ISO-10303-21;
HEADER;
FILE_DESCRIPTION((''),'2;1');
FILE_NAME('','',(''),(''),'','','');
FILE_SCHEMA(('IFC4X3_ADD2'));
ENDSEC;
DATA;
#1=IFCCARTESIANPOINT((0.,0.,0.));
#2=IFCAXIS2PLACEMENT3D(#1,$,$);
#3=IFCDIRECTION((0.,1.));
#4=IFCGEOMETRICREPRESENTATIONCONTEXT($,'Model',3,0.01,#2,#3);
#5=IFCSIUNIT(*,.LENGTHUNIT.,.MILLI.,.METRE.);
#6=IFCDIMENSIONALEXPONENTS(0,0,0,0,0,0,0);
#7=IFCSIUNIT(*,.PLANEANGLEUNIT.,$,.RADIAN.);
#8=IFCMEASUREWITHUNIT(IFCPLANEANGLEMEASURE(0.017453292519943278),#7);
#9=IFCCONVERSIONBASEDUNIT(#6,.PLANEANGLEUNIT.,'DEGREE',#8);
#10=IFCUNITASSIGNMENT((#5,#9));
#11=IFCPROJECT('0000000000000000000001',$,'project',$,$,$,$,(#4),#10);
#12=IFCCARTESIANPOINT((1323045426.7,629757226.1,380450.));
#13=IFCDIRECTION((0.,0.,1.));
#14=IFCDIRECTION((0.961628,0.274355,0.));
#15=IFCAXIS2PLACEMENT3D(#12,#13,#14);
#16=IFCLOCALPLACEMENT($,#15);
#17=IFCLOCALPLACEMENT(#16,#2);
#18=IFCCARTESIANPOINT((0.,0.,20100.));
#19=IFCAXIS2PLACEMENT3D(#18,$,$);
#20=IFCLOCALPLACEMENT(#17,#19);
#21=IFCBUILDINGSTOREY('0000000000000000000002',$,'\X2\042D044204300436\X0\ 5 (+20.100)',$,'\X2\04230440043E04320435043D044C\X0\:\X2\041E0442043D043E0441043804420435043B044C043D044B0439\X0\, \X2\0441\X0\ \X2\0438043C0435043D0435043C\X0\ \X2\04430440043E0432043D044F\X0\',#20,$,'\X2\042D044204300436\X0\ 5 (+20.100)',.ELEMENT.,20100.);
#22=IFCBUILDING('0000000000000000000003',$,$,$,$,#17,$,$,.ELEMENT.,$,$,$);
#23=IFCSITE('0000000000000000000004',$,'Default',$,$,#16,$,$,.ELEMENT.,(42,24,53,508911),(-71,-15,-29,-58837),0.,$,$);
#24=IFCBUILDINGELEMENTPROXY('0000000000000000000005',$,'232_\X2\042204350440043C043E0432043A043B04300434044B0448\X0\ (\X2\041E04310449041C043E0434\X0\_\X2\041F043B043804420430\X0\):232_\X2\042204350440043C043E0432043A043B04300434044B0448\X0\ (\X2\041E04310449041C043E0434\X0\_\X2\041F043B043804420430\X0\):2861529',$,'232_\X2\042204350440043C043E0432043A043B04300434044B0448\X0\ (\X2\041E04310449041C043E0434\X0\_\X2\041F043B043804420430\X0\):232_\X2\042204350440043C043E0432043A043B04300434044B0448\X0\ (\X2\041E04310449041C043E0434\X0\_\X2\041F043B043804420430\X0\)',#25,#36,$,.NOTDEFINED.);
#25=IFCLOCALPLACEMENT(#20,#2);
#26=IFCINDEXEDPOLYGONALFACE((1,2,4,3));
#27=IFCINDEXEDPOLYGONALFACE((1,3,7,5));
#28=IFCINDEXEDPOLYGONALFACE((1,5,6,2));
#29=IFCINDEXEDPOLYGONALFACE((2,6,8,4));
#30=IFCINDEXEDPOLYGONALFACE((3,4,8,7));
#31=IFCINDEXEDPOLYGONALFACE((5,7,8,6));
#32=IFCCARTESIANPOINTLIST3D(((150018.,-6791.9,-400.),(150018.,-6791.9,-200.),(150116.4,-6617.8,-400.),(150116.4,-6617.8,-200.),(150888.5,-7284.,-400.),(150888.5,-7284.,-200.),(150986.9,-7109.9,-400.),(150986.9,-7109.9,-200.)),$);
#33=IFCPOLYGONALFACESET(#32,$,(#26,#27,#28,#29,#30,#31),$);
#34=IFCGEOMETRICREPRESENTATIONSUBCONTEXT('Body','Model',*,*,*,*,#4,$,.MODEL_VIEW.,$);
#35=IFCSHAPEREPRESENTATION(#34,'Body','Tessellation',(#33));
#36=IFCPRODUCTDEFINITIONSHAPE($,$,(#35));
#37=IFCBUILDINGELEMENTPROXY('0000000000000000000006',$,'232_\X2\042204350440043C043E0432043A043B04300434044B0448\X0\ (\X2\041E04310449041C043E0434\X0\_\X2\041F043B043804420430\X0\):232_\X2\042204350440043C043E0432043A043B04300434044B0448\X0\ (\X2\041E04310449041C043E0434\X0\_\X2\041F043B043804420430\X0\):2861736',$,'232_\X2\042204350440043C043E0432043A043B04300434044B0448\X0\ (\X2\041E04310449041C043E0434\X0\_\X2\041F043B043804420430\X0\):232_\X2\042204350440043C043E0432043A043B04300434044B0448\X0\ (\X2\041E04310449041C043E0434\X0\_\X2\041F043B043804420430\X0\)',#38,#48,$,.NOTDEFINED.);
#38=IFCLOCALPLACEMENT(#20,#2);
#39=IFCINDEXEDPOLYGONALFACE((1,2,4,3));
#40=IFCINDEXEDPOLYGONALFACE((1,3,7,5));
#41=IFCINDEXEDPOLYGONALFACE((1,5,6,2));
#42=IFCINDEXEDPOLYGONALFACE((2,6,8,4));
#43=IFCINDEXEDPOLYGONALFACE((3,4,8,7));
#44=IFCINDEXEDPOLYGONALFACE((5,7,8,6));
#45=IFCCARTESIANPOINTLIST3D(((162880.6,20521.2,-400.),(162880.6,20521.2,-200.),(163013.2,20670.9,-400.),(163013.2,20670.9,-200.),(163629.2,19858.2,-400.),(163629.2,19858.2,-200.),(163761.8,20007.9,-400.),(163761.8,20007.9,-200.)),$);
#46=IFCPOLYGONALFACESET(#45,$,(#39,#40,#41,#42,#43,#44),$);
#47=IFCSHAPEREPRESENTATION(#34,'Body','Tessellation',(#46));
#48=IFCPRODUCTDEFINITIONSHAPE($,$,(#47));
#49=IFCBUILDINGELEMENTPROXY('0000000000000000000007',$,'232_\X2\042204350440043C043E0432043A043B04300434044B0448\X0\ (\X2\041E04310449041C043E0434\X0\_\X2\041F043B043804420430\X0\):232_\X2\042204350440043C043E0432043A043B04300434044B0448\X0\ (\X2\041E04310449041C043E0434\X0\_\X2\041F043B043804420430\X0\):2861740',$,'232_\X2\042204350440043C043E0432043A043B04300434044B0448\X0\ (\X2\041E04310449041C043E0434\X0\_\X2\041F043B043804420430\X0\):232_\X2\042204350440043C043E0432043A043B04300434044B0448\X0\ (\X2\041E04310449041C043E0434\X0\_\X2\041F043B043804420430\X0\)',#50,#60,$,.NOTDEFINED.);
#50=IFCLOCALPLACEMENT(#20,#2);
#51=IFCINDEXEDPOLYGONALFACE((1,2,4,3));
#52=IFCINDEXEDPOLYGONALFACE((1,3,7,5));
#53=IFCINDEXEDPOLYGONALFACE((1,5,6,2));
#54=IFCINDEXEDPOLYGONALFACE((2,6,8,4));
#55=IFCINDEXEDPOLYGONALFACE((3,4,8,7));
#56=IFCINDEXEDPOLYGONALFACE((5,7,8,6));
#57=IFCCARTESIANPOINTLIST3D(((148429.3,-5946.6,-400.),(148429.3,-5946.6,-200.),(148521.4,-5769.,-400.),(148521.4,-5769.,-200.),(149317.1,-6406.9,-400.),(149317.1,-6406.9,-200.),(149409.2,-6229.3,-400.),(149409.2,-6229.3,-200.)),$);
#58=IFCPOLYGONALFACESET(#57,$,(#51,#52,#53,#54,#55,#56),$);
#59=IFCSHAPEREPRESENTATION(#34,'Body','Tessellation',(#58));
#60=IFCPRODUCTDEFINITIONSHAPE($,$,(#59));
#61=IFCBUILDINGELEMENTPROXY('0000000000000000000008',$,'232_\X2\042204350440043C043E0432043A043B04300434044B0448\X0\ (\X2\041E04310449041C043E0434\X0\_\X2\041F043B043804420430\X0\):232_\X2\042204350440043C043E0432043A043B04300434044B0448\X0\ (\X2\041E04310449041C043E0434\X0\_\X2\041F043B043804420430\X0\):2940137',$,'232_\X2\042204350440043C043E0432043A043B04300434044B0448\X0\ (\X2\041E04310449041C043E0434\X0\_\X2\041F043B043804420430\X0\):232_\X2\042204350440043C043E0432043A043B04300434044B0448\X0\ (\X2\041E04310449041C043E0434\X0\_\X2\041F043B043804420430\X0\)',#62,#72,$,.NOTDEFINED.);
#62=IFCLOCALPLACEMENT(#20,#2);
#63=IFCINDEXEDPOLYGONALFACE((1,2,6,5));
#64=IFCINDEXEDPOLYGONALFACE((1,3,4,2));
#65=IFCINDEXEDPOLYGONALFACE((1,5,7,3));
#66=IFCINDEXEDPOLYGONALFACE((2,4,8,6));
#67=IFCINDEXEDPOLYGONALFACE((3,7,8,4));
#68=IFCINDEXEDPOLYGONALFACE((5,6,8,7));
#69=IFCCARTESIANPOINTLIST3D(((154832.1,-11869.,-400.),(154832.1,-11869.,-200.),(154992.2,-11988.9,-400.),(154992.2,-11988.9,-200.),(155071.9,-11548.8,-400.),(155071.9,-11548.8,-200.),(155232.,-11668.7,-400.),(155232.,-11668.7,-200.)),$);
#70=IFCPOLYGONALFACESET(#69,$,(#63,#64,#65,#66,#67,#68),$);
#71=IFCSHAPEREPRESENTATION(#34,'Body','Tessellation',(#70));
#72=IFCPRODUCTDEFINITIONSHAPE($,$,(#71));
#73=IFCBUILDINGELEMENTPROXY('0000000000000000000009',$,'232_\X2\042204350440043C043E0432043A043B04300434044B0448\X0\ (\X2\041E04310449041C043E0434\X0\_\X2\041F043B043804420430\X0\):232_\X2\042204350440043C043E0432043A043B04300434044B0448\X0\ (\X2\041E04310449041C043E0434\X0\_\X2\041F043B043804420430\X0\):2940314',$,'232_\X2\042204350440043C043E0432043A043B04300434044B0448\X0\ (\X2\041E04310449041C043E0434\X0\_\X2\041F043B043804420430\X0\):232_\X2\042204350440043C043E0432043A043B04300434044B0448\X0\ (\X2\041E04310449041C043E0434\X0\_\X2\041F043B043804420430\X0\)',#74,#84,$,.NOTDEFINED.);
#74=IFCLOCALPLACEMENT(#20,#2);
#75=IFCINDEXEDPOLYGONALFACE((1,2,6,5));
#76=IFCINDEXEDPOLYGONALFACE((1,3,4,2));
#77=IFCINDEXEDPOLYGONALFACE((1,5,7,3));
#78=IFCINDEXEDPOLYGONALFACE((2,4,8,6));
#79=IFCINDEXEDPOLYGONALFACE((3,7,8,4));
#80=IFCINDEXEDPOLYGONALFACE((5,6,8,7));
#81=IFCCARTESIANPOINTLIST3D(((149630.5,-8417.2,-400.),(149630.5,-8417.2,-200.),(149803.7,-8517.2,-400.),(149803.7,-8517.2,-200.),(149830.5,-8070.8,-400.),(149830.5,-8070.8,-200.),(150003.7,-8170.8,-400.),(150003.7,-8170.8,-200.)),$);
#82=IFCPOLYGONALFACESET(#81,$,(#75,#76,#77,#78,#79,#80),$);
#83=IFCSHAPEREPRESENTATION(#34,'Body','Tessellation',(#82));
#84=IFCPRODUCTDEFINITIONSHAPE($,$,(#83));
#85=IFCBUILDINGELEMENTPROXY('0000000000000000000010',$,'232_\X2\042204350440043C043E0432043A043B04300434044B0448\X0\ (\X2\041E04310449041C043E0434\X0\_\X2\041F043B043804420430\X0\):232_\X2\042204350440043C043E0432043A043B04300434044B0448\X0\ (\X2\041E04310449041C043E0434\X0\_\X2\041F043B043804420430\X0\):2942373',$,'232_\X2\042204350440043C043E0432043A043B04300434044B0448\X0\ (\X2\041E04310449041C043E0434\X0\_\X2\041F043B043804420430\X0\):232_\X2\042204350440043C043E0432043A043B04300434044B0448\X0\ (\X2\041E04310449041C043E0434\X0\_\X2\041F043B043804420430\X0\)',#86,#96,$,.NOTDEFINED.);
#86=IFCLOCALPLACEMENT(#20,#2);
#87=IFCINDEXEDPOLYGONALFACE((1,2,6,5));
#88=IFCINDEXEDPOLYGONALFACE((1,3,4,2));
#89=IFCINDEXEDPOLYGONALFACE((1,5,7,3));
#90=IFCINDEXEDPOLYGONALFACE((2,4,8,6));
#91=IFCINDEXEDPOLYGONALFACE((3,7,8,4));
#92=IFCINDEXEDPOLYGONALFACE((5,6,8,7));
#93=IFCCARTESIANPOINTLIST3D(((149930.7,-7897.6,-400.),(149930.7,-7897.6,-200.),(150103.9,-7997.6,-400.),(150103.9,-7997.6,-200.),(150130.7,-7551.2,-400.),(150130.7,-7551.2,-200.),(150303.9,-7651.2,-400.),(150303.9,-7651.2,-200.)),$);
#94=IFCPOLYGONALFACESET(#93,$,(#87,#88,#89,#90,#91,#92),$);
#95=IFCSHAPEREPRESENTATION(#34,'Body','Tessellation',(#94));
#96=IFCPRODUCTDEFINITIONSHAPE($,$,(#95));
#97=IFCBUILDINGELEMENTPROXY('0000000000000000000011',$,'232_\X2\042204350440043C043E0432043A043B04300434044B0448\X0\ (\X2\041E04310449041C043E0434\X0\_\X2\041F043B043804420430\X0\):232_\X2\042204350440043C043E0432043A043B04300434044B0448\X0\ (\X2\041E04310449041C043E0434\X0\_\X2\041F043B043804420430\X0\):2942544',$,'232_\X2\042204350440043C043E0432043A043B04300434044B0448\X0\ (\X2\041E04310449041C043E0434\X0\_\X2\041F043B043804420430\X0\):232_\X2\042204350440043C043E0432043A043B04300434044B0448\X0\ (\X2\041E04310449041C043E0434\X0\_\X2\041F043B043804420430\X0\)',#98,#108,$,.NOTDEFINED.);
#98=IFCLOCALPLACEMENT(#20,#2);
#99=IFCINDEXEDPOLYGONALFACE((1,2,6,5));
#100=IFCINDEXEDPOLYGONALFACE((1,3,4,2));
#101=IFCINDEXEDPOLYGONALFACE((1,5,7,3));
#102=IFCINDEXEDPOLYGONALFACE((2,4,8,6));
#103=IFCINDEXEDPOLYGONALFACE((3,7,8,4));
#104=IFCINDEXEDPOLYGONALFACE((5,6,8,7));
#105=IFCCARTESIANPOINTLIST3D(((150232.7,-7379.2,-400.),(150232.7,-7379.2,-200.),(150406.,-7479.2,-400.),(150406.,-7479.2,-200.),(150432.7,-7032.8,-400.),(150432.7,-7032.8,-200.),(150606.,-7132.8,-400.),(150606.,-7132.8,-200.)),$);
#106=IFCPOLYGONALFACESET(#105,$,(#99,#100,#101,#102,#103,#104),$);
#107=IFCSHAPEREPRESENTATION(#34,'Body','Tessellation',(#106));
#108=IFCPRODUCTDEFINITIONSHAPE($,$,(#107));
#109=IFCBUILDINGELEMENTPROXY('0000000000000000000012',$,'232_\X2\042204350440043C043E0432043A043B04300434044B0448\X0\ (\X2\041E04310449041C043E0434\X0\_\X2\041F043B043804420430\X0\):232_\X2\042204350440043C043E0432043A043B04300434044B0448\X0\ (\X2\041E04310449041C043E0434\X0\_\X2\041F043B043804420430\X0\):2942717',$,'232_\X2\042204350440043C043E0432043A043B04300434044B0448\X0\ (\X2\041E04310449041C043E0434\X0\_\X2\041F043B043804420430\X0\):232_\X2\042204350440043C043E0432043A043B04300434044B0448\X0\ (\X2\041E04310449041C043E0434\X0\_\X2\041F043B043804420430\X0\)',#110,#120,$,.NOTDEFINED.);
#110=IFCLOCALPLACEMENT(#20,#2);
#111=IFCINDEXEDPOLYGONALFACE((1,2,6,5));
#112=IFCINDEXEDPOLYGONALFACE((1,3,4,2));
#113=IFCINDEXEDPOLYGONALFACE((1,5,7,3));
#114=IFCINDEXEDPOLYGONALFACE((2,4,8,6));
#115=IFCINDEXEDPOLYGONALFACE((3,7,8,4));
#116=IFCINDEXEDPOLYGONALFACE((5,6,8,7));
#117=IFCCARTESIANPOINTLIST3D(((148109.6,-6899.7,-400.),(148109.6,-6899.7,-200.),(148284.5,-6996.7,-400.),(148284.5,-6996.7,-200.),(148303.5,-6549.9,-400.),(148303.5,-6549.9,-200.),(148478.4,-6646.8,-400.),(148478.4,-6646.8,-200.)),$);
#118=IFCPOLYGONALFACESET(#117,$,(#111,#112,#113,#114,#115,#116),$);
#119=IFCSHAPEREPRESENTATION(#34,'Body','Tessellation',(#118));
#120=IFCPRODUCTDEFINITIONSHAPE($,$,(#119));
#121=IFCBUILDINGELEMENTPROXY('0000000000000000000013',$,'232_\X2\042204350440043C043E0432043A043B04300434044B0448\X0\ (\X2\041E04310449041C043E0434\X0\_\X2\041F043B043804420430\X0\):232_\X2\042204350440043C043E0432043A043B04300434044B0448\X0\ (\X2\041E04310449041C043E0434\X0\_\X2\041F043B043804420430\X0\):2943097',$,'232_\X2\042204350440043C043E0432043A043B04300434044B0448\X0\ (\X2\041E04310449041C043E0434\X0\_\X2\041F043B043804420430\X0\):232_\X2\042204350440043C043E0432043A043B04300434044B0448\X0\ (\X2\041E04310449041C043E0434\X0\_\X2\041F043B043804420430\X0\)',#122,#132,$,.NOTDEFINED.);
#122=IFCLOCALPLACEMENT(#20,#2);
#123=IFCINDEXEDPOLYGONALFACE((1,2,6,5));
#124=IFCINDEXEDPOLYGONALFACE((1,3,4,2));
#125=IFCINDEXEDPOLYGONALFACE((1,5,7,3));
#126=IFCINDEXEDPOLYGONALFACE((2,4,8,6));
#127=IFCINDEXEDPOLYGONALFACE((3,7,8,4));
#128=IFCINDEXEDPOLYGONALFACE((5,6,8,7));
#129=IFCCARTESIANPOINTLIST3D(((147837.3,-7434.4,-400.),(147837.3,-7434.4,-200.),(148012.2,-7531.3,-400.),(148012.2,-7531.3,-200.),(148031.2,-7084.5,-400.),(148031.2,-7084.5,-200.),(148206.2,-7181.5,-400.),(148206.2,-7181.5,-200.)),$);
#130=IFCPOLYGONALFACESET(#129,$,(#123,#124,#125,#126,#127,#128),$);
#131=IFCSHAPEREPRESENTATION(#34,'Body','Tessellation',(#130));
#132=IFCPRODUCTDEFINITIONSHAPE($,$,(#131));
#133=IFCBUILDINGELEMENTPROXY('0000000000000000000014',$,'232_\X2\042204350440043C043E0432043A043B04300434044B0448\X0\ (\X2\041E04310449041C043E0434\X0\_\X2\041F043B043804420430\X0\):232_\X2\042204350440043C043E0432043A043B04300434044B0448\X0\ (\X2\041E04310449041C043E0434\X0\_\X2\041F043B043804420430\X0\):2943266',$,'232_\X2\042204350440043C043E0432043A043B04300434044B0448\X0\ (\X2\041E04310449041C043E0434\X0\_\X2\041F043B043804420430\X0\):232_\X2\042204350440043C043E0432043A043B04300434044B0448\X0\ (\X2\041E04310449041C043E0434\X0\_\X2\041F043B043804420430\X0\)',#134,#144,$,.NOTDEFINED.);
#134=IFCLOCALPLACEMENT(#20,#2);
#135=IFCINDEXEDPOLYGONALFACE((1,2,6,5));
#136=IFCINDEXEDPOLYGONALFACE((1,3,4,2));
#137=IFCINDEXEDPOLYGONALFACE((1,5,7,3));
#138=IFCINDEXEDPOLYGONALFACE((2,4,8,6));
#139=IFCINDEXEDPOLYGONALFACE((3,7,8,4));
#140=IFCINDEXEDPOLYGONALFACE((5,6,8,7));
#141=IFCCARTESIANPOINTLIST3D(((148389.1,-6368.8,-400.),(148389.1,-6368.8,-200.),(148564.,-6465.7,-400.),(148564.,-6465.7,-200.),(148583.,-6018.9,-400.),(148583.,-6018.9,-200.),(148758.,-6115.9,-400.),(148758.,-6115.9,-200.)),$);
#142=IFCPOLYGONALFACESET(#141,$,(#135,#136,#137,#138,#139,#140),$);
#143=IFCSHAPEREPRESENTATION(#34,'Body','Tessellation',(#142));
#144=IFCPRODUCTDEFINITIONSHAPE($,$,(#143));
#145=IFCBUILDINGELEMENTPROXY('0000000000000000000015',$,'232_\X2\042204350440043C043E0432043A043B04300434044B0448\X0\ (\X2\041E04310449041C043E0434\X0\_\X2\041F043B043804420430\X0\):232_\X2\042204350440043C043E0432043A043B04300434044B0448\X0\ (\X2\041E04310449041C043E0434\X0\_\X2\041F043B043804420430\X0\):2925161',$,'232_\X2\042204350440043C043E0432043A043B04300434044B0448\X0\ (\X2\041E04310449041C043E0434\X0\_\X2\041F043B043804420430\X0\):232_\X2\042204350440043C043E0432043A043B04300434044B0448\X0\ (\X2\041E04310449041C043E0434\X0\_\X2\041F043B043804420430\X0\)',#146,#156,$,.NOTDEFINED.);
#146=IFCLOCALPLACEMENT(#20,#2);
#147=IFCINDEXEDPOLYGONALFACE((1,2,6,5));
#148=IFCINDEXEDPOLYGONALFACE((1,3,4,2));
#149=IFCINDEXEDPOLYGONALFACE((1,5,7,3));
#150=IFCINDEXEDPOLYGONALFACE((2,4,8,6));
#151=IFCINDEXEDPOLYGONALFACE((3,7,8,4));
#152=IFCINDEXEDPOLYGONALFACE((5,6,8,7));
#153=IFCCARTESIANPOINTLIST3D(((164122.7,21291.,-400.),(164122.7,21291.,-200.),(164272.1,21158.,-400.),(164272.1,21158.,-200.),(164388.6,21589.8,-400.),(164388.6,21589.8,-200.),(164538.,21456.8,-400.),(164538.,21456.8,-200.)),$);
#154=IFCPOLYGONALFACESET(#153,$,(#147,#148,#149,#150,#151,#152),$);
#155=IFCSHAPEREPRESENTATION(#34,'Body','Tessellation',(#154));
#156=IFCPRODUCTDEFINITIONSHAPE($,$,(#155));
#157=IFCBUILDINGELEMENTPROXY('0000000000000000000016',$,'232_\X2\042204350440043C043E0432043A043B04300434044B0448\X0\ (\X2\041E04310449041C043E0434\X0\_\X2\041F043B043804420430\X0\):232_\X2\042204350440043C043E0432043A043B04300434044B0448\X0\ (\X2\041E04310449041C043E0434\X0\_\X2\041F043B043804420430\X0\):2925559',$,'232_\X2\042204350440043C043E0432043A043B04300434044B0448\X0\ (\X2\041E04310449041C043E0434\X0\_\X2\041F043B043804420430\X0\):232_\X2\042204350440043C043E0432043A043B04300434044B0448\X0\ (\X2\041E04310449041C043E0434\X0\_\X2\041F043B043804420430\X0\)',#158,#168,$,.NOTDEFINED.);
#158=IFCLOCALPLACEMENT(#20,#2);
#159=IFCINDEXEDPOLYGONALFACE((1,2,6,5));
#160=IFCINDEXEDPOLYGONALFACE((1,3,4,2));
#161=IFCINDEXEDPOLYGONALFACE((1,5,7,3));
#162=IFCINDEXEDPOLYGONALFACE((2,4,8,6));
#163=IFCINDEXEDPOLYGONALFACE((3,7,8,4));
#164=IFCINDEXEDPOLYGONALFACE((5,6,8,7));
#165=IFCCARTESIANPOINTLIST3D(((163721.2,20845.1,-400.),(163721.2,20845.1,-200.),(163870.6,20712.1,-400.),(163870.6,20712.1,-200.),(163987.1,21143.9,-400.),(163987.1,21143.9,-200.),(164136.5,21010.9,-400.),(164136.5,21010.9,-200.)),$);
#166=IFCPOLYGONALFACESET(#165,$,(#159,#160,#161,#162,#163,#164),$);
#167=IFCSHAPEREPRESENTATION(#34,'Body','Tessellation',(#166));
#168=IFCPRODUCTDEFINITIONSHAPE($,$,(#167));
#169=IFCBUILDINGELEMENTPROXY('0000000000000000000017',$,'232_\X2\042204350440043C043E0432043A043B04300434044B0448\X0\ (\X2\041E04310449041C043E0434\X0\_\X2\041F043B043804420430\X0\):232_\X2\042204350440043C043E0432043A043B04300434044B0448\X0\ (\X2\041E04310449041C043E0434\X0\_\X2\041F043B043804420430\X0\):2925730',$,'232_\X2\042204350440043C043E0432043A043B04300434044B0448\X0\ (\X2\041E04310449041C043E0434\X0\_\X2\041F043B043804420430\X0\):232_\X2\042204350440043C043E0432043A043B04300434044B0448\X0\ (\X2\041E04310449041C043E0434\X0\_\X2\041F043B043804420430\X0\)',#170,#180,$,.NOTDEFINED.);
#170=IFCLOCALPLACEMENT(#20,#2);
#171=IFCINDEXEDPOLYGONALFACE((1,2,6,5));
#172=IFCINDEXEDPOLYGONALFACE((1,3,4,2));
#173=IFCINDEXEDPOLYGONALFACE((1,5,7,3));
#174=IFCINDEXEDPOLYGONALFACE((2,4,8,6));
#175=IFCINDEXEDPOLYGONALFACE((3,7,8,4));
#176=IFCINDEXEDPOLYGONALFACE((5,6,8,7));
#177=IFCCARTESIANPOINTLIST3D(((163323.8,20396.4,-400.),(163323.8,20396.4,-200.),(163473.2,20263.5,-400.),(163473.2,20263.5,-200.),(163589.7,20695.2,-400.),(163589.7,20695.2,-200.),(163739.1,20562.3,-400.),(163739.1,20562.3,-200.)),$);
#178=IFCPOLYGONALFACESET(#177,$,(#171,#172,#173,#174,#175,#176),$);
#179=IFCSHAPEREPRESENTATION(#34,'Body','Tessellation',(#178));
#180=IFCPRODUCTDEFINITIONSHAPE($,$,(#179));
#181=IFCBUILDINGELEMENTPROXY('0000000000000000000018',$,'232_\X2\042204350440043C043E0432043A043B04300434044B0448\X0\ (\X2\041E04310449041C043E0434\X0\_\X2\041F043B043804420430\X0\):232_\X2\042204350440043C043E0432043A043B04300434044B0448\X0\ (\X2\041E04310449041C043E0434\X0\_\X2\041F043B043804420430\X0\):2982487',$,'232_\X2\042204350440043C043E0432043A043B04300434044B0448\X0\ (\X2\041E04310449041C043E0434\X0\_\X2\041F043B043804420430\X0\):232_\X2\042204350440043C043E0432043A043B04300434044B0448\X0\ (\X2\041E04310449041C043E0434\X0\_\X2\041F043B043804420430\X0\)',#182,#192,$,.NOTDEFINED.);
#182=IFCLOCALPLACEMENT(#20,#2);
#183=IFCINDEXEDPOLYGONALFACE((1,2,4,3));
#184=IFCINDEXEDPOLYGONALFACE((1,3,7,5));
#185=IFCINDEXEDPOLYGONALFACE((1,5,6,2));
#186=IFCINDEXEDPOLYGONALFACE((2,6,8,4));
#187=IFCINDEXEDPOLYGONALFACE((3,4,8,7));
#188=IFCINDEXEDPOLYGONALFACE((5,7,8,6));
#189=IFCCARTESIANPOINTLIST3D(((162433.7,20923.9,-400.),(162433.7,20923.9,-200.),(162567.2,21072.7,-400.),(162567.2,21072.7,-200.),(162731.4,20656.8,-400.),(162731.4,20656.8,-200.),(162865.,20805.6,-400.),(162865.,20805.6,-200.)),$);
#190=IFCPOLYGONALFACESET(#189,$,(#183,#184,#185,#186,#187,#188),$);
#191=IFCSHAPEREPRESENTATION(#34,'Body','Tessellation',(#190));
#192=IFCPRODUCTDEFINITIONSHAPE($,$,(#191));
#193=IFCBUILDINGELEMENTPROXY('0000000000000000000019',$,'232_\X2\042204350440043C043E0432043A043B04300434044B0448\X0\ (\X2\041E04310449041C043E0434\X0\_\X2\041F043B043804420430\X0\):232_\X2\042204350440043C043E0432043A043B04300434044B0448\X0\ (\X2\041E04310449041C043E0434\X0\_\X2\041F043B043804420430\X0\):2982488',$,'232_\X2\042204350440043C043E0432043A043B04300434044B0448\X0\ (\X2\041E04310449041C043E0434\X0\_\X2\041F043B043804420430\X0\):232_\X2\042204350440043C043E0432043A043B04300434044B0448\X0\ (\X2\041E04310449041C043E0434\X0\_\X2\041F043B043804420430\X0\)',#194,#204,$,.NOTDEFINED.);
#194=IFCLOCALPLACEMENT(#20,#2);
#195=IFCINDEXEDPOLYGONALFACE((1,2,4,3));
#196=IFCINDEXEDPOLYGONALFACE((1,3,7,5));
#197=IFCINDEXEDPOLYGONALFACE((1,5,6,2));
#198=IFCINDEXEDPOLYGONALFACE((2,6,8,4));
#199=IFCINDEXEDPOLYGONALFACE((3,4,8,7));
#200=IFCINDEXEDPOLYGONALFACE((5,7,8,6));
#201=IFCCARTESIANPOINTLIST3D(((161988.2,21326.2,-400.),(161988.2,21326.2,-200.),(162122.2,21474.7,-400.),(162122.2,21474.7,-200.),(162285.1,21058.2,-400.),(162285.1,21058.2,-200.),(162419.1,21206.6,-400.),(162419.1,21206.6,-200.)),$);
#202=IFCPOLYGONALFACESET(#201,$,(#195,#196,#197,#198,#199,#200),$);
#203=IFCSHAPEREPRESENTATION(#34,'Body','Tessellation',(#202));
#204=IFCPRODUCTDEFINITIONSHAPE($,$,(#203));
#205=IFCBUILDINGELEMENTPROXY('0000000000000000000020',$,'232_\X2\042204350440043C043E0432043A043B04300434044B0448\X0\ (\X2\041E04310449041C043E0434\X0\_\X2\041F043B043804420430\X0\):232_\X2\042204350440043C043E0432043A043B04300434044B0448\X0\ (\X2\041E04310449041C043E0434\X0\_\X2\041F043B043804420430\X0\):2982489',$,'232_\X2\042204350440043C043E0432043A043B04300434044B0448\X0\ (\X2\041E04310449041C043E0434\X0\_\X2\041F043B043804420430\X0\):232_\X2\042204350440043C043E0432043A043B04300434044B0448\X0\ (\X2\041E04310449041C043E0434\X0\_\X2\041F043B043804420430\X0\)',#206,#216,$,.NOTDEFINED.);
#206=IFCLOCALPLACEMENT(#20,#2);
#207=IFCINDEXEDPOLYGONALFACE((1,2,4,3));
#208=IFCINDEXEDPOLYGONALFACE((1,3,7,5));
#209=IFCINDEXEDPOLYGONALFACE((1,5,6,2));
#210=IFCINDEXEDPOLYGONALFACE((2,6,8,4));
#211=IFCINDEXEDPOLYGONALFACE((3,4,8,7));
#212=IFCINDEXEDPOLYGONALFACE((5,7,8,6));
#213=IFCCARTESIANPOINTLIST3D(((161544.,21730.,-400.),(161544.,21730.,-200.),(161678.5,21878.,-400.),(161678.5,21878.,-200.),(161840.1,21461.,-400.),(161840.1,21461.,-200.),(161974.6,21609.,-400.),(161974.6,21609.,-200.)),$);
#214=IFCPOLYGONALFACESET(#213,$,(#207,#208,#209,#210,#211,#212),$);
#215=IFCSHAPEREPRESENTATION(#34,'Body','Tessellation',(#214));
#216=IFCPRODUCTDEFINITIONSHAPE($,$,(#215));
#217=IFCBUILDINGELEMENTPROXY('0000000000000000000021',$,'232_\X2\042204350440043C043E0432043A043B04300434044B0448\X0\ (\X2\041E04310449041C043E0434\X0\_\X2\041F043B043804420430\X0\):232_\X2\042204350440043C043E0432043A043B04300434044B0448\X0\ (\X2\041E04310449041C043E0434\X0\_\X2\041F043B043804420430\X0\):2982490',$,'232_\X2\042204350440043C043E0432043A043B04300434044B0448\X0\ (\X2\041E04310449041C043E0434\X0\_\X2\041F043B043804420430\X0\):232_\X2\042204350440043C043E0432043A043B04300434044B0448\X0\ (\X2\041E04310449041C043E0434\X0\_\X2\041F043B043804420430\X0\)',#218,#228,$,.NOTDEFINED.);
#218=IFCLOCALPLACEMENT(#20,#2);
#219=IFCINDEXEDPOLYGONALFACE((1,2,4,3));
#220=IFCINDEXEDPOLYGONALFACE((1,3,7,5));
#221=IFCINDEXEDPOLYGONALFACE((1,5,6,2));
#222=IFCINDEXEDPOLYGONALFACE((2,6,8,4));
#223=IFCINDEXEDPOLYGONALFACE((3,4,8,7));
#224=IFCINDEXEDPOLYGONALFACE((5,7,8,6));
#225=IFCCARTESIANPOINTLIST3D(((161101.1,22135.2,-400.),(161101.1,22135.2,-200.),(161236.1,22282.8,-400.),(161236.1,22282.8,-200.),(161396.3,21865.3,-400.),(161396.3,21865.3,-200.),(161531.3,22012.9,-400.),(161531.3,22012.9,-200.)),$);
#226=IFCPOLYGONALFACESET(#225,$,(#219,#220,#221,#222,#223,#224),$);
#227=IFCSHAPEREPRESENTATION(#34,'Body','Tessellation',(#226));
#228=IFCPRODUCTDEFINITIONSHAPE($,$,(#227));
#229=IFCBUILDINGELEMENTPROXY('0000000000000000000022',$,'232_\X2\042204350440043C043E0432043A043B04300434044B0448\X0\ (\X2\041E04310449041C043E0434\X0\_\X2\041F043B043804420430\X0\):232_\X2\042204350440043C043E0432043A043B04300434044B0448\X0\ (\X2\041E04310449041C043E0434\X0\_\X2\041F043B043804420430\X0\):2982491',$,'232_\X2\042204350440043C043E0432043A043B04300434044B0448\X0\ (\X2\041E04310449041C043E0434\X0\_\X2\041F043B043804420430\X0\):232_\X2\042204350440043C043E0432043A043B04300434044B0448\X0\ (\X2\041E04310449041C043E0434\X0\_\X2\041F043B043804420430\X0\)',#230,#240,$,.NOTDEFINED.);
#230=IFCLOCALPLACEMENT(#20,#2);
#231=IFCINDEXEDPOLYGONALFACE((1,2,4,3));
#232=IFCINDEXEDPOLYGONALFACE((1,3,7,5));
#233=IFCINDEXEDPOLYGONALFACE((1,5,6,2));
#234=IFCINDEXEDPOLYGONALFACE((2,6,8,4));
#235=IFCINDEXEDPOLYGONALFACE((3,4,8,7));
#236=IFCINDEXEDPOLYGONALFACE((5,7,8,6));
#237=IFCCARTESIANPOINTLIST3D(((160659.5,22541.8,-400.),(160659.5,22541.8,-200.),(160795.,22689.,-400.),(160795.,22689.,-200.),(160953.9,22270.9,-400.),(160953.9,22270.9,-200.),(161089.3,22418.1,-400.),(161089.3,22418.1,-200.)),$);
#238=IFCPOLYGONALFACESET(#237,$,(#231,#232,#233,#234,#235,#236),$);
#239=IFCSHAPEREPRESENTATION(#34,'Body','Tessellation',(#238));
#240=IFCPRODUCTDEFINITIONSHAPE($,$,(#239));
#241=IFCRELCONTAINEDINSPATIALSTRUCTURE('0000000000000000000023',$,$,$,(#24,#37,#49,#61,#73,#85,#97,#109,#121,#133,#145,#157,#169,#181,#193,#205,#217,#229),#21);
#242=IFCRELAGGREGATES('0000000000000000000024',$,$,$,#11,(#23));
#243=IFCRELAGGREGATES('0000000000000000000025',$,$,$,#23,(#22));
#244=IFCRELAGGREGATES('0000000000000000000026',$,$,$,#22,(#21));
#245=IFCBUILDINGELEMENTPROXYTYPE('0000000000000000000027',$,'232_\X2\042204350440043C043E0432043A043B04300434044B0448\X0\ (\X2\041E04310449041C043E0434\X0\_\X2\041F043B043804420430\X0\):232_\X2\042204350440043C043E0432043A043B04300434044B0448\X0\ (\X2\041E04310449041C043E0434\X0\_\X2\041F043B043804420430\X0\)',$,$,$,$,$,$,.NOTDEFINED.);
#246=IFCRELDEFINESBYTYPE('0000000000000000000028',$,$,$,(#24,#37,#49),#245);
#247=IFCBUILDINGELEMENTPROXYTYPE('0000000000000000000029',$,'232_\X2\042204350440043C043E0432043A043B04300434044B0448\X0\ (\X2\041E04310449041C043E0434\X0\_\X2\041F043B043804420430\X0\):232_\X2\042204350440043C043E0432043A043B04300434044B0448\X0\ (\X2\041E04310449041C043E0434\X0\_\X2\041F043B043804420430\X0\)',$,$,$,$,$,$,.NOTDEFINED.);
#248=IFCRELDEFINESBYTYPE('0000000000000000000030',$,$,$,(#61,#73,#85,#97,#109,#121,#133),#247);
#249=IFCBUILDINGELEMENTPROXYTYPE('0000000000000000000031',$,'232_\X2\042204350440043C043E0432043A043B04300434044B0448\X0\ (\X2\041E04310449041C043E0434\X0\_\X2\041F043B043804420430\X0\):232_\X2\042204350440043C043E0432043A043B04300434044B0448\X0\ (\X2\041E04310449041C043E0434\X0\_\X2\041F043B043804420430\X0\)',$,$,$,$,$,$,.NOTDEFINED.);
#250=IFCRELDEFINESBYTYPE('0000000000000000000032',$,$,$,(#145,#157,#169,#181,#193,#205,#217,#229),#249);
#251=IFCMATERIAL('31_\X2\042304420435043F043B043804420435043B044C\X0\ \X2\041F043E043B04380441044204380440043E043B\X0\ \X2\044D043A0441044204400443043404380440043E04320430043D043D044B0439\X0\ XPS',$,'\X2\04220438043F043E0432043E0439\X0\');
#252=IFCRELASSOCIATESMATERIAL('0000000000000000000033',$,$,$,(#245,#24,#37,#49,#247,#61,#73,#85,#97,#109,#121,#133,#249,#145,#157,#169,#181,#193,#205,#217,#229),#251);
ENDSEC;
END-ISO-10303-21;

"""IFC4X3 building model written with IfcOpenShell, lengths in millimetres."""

from ifc_helpers import new_model, entity, si_unit, converted_unit, direction, frame, origin, origin_2d_with_axis, place, context, subcontext, project, spatial, rectangle, extrude, source, transform, mapped, material, type_object, type_shapes, element, save


model = new_model("IFC4X3")

# Units and contexts
model_context = context("Model", 3, precision=0.01, world=origin(), true_north=direction((0.0, 1.0)))
body_context = subcontext(model_context, "Body", "Model", "MODEL_VIEW")
ifc_project = project(units=[si_unit("LENGTHUNIT", "METRE", prefix="MILLI"), converted_unit("PLANEANGLEUNIT", "DEGREE", entity("IfcPlaneAngleMeasure", 0.017453292519943278), si_unit("PLANEANGLEUNIT", "RADIAN"), dimensions=[0, 0, 0, 0, 0, 0, 0])], contexts=[model_context])

# Site, building, storey
site_placement = place(None, frame((1323045426.7, 629757226.1, 380450.0), z_axis=(0.0, 0.0, 1.0), x_axis=(0.961628, 0.274355, 0.0)))
site = spatial("IfcSite", under=ifc_project, at=site_placement, Name="Default", CompositionType="ELEMENT", RefLatitude=(42, 24, 53, 508911), RefLongitude=(-71, -15, -29, -58837), RefElevation=0.0)
building_placement = place(site_placement, origin())
building = spatial("IfcBuilding", under=site, at=building_placement, CompositionType="ELEMENT")
storey_placement = place(building_placement, frame((0.0, 0.0, 20100.0)))
storey = spatial("IfcBuildingStorey", under=building, at=storey_placement, Name="Этаж 5 (+20.100)", ObjectType="Уровень:Относительный, с именем уровня", LongName="Этаж 5 (+20.100)", CompositionType="ELEMENT", Elevation=20100.0)

# Building element proxies
ifc_material_1 = material(Name="31_Утеплитель Полистирол экструдированный XPS", Category="Типовой")
building_element_proxy_type_1 = type_object("IfcBuildingElementProxyType", Name="232_Термовкладыш (ОбщМод_Плита):232_Термовкладыш (ОбщМод_Плита)", PredefinedType="NOTDEFINED", material=ifc_material_1)
shared_shape_1 = source(origin(), body_context, "Body", "SweptSolid", [
    extrude(rectangle(XDim=1000.0, YDim=200.0, at=origin_2d_with_axis()), frame((500.0, 0.0, -200.0), z_axis=(0.0, 0.0, 1.0), x_axis=(-1.0, 0.0, 0.0)), (0.0, 0.0, 1.0), 200.0),
])
type_shapes(building_element_proxy_type_1, [shared_shape_1])
for number, where, z_axis, x_axis, name in (
    (1, (150067.2, -6704.9, -200.0), (0.0, 0.0, 1.0), (0.870534, -0.492108, 0.0), "232_Термовкладыш (ОбщМод_Плита):232_Термовкладыш (ОбщМод_Плита):2861529"),
    (2, (163695.5, 19933.0, -200.0), (0.0, 0.0, 1.0), (-0.748586, 0.663037, 0.0), "232_Термовкладыш (ОбщМод_Плита):232_Термовкладыш (ОбщМод_Плита):2861736"),
    (3, (148475.3, -5857.8, -200.0), (0.0, 0.0, 1.0), (0.887786, -0.460256, 0.0), "232_Термовкладыш (ОбщМод_Плита):232_Термовкладыш (ОбщМод_Плита):2861740"),
):
    element("IfcBuildingElementProxy", number, at=place(storey_placement, frame(where, z_axis=z_axis, x_axis=x_axis)), inside=storey, type_object=building_element_proxy_type_1, material=ifc_material_1, Name=name, ObjectType="232_Термовкладыш (ОбщМод_Плита):232_Термовкладыш (ОбщМод_Плита)", PredefinedType="NOTDEFINED", context=body_context, shape_type="MappedRepresentation", body=[
        mapped(shared_shape_1, transform((0.0, 0.0, 0.0), scale=1.0)),
    ])
building_element_proxy_type_2 = type_object("IfcBuildingElementProxyType", Name="232_Термовкладыш (ОбщМод_Плита):232_Термовкладыш (ОбщМод_Плита)", PredefinedType="NOTDEFINED", material=ifc_material_1)
shared_shape_2 = source(origin(), body_context, "Body", "SweptSolid", [
    extrude(rectangle(XDim=200.0, YDim=400.0, at=origin_2d_with_axis()), frame((100.0, 0.0, -200.0), z_axis=(0.0, 0.0, 1.0), x_axis=(-1.0, 0.0, 0.0)), (0.0, 0.0, 1.0), 200.0),
])
type_shapes(building_element_proxy_type_2, [shared_shape_2])
for number, where, z_axis, x_axis, name in (
    (4, (154952.0, -11708.9, -200.0), (0.0, 0.0, 1.0), (0.800379, -0.599495, 0.0), "232_Термовкладыш (ОбщМод_Плита):232_Термовкладыш (ОбщМод_Плита):2940137"),
    (5, (149730.5, -8244.0, -200.0), (0.0, 0.0, 1.0), (0.866025, -0.5, 0.0), "232_Термовкладыш (ОбщМод_Плита):232_Термовкладыш (ОбщМод_Плита):2940314"),
    (6, (150030.7, -7724.4, -200.0), (0.0, 0.0, 1.0), (0.866025, -0.5, 0.0), "232_Термовкладыш (ОбщМод_Плита):232_Термовкладыш (ОбщМод_Плита):2942373"),
    (7, (150332.7, -7206.0, -200.0), (0.0, 0.0, 1.0), (0.866025, -0.5, 0.0), "232_Термовкладыш (ОбщМод_Плита):232_Термовкладыш (ОбщМод_Плита):2942544"),
    (8, (148206.6, -6724.8, -200.0), (0.0, 0.0, 1.0), (0.87462, -0.48481, 0.0), "232_Термовкладыш (ОбщМод_Плита):232_Термовкладыш (ОбщМод_Плита):2942717"),
    (9, (147934.3, -7259.4, -200.0), (0.0, 0.0, 1.0), (0.87462, -0.48481, 0.0), "232_Термовкладыш (ОбщМод_Плита):232_Термовкладыш (ОбщМод_Плита):2943097"),
    (10, (148486.1, -6193.8, -200.0), (0.0, 0.0, 1.0), (0.87462, -0.48481, 0.0), "232_Термовкладыш (ОбщМод_Плита):232_Термовкладыш (ОбщМод_Плита):2943266"),
):
    element("IfcBuildingElementProxy", number, at=place(storey_placement, frame(where, z_axis=z_axis, x_axis=x_axis)), inside=storey, type_object=building_element_proxy_type_2, material=ifc_material_1, Name=name, ObjectType="232_Термовкладыш (ОбщМод_Плита):232_Термовкладыш (ОбщМод_Плита)", PredefinedType="NOTDEFINED", context=body_context, shape_type="MappedRepresentation", body=[
        mapped(shared_shape_2, transform((0.0, 0.0, 0.0), scale=1.0)),
    ])
building_element_proxy_type_3 = type_object("IfcBuildingElementProxyType", Name="232_Термовкладыш (ОбщМод_Плита):232_Термовкладыш (ОбщМод_Плита)", PredefinedType="NOTDEFINED", material=ifc_material_1)
shared_shape_3 = source(origin(), body_context, "Body", "SweptSolid", [
    extrude(rectangle(XDim=400.0, YDim=200.0, at=origin_2d_with_axis()), frame((200.0, 0.0, -200.0), z_axis=(0.0, 0.0, 1.0), x_axis=(-1.0, 0.0, 0.0)), (0.0, 0.0, 1.0), 200.0),
])
type_shapes(building_element_proxy_type_3, [shared_shape_3])
for number, where, z_axis, x_axis, name in (
    (11, (164197.4, 21224.5, -200.0), (0.0, 0.0, 1.0), (0.664762, 0.747056, 0.0), "232_Термовкладыш (ОбщМод_Плита):232_Термовкладыш (ОбщМод_Плита):2925161"),
    (12, (163795.9, 20778.6, -200.0), (0.0, 0.0, 1.0), (0.664762, 0.747056, 0.0), "232_Термовкладыш (ОбщМод_Плита):232_Термовкладыш (ОбщМод_Плита):2925559"),
    (13, (163398.5, 20329.9, -200.0), (0.0, 0.0, 1.0), (0.664762, 0.747056, 0.0), "232_Термовкладыш (ОбщМод_Плита):232_Термовкладыш (ОбщМод_Плита):2925730"),
    (14, (162798.2, 20731.2, -200.0), (0.0, 0.0, 1.0), (-0.744345, 0.667796, 0.0), "232_Термовкладыш (ОбщМод_Плита):232_Термовкладыш (ОбщМод_Плита):2982487"),
    (15, (162352.1, 21132.4, -200.0), (0.0, 0.0, 1.0), (-0.742212, 0.670165, 0.0), "232_Термовкладыш (ОбщМод_Плита):232_Термовкладыш (ОбщМод_Плита):2982488"),
    (16, (161907.3, 21535.0, -200.0), (0.0, 0.0, 1.0), (-0.740073, 0.672527, 0.0), "232_Термовкладыш (ОбщМод_Плита):232_Термовкладыш (ОбщМод_Плита):2982489"),
    (17, (161463.8, 21939.1, -200.0), (0.0, 0.0, 1.0), (-0.737925, 0.674882, 0.0), "232_Термовкладыш (ОбщМод_Плита):232_Термовкладыш (ОбщМод_Плита):2982490"),
    (18, (161021.6, 22344.5, -200.0), (0.0, 0.0, 1.0), (-0.735771, 0.677231, 0.0), "232_Термовкладыш (ОбщМод_Плита):232_Термовкладыш (ОбщМод_Плита):2982491"),
):
    element("IfcBuildingElementProxy", number, at=place(storey_placement, frame(where, z_axis=z_axis, x_axis=x_axis)), inside=storey, type_object=building_element_proxy_type_3, material=ifc_material_1, Name=name, ObjectType="232_Термовкладыш (ОбщМод_Плита):232_Термовкладыш (ОбщМод_Плита)", PredefinedType="NOTDEFINED", context=body_context, shape_type="MappedRepresentation", body=[
        mapped(shared_shape_3, transform((0.0, 0.0, 0.0), scale=1.0)),
    ])

save(model, "model.ifc")
